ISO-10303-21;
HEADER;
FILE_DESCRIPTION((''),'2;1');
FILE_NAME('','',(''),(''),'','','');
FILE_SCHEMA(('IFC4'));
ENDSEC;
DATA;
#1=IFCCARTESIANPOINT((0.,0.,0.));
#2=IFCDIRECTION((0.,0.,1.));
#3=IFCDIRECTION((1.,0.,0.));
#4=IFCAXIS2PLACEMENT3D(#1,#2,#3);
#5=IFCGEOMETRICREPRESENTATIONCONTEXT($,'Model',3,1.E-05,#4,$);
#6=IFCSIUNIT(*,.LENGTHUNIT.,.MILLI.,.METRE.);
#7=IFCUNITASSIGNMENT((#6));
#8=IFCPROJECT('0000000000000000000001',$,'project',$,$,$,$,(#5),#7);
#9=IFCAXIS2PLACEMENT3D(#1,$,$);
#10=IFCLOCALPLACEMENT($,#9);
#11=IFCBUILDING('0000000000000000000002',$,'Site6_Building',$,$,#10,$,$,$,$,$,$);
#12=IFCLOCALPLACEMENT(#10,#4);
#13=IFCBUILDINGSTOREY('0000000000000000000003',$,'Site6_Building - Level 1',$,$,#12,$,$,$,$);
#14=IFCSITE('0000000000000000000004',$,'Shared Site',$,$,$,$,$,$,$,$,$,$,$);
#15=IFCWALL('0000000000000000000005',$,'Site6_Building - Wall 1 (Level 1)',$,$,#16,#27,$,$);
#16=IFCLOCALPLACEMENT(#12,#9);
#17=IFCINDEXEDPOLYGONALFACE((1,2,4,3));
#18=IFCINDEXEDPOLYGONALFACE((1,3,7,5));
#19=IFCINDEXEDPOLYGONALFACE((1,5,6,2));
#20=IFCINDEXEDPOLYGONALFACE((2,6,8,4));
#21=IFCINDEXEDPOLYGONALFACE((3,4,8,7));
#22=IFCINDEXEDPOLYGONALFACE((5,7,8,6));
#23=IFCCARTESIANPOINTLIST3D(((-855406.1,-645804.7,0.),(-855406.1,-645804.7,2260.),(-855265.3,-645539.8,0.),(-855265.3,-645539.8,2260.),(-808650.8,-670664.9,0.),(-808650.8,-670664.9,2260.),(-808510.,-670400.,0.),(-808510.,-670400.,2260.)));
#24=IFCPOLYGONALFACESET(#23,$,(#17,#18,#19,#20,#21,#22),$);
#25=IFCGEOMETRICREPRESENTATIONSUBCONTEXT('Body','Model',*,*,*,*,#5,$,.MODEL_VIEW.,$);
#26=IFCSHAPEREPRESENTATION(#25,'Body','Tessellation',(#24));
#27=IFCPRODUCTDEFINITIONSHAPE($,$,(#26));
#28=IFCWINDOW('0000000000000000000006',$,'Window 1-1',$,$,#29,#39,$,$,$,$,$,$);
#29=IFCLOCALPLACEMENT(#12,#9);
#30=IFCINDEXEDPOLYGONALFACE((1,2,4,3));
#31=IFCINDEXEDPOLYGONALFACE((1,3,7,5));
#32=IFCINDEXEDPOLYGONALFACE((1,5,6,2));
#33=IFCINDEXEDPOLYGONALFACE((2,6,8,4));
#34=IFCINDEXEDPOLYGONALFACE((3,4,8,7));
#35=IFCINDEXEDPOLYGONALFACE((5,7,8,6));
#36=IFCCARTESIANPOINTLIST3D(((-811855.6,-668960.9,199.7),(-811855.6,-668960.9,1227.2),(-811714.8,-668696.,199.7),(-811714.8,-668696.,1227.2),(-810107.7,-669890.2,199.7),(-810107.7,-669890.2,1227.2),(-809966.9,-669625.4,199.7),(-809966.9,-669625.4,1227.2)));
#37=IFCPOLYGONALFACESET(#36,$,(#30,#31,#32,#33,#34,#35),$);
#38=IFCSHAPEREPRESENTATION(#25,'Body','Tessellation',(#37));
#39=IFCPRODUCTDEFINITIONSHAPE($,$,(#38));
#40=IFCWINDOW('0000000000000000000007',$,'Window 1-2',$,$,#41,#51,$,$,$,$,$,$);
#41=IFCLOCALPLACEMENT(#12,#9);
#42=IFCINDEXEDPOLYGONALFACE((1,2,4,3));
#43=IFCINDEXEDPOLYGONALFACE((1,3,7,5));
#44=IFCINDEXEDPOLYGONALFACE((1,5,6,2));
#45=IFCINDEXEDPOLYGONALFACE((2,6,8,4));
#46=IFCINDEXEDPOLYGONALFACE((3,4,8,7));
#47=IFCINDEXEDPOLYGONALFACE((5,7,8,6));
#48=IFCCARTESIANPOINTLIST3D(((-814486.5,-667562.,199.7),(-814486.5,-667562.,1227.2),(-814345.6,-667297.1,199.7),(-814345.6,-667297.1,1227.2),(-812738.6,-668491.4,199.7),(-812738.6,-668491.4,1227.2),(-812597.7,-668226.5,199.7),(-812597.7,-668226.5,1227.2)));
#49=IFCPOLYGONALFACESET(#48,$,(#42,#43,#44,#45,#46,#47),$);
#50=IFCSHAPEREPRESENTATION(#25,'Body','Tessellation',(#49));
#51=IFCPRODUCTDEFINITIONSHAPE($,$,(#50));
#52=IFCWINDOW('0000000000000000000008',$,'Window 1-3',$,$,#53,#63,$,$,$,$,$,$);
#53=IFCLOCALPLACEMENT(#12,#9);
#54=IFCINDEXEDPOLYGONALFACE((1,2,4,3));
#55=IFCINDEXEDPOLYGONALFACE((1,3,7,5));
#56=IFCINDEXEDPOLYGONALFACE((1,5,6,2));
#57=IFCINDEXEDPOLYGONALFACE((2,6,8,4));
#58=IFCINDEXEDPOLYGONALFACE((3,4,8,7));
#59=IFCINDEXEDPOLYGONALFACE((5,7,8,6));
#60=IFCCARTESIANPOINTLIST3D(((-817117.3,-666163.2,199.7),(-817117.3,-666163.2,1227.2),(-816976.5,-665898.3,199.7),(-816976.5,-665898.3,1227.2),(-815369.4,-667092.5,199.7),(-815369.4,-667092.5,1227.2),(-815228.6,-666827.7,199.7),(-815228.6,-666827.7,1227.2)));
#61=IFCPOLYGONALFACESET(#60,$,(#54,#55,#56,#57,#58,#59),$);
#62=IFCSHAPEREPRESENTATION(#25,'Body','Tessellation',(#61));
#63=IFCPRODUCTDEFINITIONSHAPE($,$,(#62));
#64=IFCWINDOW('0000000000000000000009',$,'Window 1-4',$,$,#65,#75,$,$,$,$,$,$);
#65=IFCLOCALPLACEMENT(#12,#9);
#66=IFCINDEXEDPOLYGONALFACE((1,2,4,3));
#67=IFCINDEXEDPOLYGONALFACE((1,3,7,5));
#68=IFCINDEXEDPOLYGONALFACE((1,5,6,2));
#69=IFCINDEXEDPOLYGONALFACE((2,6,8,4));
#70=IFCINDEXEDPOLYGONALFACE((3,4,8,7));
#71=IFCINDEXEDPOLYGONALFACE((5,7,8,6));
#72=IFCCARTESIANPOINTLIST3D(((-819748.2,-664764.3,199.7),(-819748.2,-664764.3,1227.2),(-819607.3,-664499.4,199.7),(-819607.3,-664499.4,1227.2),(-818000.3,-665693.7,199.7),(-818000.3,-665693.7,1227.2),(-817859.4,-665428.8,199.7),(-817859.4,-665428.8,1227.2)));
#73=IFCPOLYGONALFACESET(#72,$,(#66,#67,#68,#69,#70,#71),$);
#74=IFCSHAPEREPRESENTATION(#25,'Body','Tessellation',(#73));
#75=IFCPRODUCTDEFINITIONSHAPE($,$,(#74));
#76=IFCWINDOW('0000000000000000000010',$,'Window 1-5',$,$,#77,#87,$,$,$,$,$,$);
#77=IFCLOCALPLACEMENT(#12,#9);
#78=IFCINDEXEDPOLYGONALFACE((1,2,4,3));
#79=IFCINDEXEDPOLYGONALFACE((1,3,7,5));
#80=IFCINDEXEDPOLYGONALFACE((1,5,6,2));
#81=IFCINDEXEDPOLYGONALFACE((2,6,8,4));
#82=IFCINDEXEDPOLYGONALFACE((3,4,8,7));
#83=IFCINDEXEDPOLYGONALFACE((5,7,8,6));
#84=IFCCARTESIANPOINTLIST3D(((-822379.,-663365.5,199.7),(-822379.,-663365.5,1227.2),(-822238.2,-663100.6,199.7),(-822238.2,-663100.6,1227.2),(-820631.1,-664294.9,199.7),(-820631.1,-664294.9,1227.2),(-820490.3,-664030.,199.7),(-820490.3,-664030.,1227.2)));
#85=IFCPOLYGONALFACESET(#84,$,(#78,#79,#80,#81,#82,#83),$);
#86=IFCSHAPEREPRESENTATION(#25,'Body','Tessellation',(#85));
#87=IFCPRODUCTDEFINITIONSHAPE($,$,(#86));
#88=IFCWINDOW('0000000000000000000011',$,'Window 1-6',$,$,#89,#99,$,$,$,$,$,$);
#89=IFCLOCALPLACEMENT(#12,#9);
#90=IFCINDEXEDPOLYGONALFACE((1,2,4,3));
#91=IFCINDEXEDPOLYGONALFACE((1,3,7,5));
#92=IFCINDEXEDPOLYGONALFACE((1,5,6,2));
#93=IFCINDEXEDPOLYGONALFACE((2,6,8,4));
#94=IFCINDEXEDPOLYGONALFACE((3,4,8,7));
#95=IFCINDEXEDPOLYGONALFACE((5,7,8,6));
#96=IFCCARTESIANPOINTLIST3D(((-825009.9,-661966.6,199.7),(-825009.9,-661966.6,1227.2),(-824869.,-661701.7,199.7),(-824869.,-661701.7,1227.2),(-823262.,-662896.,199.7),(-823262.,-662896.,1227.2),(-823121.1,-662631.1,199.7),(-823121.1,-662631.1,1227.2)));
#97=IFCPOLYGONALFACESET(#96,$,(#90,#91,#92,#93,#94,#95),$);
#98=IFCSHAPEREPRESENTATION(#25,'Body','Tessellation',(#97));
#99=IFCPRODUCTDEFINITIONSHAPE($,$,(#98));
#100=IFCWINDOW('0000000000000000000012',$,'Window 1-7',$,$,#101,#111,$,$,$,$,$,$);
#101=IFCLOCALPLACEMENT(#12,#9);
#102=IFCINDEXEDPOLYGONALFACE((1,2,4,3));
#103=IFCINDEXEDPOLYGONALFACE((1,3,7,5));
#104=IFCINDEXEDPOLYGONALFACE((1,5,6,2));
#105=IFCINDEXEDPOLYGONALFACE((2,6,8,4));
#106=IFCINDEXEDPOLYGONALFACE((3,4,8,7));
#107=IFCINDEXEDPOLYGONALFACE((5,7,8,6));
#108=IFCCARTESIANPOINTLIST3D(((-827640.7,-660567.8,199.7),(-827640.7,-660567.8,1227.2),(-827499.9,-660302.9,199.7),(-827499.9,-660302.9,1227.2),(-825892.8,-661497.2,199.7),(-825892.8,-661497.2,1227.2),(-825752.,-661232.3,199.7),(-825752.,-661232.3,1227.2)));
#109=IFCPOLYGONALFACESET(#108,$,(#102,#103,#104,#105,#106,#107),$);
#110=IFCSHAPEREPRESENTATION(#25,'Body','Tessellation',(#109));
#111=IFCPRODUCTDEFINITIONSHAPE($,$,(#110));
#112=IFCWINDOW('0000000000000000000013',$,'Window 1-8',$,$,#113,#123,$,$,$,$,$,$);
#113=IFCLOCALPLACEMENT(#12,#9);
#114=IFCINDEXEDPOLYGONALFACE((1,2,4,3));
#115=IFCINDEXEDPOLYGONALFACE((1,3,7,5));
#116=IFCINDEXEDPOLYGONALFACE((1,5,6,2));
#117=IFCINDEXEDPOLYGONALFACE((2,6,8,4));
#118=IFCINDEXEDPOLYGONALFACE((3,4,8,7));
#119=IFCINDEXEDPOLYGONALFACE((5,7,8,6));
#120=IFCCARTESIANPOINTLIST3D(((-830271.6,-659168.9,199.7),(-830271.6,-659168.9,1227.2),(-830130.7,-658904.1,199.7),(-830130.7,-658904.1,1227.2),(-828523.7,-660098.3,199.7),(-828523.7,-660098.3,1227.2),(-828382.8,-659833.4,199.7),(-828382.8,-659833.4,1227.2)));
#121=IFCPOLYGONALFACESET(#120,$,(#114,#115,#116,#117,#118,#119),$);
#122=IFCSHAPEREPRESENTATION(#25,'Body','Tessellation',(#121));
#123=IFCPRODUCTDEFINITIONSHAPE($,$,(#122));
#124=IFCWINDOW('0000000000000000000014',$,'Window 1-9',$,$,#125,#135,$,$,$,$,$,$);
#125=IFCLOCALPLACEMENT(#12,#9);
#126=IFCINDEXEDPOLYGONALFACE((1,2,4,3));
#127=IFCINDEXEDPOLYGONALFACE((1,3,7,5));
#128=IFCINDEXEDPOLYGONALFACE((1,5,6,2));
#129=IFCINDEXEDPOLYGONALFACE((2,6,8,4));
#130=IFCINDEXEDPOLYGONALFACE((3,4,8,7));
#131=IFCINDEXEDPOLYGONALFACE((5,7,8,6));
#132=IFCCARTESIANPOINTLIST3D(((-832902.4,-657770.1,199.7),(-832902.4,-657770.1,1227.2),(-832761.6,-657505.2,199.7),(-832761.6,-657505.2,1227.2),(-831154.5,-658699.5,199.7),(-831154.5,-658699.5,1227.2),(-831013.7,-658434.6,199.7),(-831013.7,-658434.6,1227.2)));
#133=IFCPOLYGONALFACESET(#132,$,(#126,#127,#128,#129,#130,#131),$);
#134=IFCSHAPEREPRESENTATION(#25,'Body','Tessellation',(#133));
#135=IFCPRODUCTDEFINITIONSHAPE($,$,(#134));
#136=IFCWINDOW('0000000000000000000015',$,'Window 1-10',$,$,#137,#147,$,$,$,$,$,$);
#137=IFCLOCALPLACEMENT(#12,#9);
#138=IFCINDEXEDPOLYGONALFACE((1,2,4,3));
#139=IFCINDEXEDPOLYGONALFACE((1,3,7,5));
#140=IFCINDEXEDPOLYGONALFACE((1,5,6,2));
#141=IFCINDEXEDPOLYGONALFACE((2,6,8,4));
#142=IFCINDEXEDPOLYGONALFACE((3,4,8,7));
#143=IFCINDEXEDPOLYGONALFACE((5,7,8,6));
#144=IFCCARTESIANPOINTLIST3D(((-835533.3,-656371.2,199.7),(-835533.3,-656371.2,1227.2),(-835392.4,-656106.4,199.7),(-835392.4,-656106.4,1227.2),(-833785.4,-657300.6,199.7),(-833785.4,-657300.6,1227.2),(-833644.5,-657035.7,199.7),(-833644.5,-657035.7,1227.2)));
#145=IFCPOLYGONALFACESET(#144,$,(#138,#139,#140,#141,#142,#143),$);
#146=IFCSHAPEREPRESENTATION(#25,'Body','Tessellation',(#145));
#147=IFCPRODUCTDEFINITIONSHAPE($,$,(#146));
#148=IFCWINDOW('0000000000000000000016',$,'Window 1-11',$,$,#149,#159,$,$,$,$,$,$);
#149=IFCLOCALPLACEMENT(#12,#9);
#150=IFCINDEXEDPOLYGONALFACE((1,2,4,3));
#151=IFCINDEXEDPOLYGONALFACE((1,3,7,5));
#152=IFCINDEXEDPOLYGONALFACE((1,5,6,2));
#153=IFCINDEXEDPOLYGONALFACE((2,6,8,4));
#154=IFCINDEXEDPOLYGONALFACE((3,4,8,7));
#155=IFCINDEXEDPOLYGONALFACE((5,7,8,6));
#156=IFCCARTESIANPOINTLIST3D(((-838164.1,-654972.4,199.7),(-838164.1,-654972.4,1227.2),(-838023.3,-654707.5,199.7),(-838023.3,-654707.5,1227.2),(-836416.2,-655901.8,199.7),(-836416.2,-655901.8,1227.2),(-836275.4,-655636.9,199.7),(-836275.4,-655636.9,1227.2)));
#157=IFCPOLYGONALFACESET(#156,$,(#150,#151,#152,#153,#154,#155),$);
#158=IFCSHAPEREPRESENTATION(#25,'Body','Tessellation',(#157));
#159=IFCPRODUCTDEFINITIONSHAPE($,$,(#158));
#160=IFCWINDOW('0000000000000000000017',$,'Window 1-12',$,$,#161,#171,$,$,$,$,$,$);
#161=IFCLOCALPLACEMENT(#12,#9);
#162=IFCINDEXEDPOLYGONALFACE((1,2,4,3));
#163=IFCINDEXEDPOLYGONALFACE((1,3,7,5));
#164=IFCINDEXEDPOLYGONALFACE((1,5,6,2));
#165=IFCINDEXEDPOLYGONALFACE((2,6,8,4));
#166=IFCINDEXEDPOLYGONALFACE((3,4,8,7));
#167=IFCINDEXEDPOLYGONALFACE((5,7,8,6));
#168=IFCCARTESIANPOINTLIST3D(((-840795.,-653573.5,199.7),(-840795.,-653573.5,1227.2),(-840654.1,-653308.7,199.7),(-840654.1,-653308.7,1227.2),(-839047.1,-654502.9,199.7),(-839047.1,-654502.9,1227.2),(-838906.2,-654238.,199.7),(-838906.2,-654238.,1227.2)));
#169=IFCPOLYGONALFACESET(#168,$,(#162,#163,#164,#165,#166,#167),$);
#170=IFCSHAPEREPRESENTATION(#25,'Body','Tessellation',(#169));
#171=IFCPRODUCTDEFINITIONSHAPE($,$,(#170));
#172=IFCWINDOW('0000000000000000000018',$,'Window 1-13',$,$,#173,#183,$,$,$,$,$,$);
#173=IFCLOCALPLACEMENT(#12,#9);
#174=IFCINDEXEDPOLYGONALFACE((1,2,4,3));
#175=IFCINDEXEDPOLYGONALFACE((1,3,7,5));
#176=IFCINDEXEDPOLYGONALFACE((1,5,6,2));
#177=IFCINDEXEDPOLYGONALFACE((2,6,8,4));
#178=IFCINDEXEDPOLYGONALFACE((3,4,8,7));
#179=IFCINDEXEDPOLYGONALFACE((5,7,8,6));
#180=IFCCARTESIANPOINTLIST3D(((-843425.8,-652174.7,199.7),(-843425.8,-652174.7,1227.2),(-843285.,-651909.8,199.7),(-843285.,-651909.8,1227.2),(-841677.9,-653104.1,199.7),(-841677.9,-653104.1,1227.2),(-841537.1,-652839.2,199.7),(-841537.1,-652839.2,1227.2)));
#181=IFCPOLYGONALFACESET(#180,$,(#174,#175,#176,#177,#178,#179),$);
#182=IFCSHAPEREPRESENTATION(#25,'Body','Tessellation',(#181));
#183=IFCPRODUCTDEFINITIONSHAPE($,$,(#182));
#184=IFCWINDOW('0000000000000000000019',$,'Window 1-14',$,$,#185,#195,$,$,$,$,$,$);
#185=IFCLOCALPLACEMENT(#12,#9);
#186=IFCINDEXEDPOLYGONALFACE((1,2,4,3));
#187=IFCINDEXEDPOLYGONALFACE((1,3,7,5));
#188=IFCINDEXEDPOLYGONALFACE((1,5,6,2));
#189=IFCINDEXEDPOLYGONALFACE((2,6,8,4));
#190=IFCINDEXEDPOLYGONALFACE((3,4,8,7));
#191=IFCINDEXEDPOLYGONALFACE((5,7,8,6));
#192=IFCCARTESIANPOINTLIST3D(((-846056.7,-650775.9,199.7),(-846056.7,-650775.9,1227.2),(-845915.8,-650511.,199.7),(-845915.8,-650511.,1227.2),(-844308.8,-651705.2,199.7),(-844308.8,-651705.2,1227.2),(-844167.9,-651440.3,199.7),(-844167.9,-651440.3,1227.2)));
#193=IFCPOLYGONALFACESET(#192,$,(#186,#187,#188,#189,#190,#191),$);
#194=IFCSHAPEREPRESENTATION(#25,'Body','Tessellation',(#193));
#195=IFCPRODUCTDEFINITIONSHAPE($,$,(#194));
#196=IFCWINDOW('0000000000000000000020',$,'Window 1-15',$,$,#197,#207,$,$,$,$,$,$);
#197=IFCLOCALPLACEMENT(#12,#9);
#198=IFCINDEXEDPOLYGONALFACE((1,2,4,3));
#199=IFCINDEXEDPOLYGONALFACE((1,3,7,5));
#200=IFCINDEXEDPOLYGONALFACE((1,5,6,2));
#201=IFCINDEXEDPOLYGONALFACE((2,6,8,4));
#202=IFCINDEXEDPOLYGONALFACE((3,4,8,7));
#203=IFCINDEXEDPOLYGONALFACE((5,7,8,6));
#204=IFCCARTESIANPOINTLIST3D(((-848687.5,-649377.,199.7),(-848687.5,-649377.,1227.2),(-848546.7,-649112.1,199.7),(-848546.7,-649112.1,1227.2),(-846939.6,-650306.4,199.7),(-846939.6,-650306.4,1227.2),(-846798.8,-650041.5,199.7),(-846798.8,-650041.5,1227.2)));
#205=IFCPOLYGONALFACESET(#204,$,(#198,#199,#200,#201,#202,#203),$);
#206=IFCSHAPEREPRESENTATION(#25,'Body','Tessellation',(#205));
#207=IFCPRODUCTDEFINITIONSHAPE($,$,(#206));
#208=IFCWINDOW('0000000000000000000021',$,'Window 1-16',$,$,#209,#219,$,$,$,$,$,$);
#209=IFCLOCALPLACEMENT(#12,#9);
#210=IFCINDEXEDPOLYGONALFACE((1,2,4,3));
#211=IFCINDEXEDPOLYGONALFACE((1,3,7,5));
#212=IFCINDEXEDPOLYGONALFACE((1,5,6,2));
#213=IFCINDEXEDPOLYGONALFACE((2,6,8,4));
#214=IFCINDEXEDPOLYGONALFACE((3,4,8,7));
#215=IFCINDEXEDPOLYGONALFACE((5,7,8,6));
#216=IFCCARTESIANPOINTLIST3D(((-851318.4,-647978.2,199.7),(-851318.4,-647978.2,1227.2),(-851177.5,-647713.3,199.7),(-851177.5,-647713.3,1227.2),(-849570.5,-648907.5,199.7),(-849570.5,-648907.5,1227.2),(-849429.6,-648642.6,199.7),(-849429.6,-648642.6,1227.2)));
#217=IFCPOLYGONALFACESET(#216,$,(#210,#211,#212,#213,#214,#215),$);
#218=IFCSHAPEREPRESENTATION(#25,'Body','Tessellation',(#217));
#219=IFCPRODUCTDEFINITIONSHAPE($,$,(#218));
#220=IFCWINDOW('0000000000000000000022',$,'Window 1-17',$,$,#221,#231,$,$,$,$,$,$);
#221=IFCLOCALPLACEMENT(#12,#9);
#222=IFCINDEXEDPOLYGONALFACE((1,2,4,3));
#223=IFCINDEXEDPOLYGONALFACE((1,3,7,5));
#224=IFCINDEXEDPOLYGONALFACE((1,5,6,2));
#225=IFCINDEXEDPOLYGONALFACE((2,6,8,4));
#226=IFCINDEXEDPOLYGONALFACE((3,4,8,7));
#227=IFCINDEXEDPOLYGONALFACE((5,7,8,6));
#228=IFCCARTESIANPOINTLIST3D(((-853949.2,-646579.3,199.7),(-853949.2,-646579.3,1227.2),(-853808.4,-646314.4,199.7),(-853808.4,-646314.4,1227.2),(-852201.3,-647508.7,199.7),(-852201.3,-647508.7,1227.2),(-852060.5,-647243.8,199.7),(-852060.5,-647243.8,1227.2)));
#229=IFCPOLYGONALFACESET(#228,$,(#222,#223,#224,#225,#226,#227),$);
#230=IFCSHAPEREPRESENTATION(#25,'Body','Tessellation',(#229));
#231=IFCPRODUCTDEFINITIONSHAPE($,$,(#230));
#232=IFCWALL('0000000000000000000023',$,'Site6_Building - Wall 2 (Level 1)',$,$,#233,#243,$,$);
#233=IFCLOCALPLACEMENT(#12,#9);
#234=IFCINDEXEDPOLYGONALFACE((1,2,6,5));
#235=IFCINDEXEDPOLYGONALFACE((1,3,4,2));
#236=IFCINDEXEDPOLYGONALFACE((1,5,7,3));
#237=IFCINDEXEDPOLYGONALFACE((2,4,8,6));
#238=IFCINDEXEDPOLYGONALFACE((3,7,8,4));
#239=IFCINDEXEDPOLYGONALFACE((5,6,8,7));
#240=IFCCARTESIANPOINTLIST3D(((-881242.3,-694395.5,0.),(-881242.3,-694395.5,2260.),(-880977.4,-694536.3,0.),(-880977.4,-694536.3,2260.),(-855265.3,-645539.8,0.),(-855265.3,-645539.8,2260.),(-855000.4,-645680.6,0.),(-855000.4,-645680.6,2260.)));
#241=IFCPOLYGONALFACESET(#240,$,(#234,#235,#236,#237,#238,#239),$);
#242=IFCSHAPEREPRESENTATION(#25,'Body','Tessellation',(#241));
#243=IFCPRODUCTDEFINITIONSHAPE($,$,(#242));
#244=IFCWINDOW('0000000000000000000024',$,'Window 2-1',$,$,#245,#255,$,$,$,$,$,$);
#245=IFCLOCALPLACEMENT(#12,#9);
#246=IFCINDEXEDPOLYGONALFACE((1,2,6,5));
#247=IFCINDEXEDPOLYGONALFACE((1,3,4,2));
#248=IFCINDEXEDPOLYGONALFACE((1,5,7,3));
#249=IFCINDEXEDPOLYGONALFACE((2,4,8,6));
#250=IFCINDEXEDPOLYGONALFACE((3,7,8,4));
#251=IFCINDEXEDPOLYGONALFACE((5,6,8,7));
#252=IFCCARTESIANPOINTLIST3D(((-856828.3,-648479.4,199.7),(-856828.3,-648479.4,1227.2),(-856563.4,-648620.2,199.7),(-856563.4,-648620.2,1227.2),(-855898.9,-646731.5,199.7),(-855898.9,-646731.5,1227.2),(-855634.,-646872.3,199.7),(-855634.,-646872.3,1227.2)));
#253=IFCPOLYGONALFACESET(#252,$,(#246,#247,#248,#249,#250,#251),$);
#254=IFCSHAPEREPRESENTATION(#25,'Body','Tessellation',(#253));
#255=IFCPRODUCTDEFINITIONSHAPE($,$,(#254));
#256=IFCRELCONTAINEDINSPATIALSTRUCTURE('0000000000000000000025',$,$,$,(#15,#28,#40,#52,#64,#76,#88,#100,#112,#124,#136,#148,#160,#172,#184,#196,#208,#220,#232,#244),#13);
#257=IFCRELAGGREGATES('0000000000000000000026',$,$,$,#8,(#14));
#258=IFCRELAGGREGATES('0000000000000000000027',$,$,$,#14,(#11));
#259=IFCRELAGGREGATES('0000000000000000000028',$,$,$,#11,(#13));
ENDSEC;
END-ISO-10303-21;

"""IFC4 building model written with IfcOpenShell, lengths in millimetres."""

from ifc_helpers import new_model, si_unit, frame, origin, origin_with_axes, place, context, subcontext, project, spatial, indexed_curve, outline, extrude, element, save


model = new_model("IFC4")

# Units and contexts
model_context = context("Model", 3, precision=1e-05, world=origin_with_axes())
body_context = subcontext(model_context, "Body", "Model", "MODEL_VIEW")
ifc_project = project(units=[si_unit("LENGTHUNIT", "METRE", prefix="MILLI")], contexts=[model_context])

# Site, building, storey
site = spatial("IfcSite", under=ifc_project, Name="Shared Site")
building_placement = place(None, origin())
building = spatial("IfcBuilding", under=site, at=building_placement, Name="Site6_Building")
storey_placement = place(building_placement, origin_with_axes())
storey = spatial("IfcBuildingStorey", under=building, at=storey_placement, Name="Site6_Building - Level 1")

# Wall
wall_1_placement = place(storey_placement, frame((-808510.0, -670400.0, 0.0), z_axis=(0.0, 0.0, 1.0), x_axis=(-0.882948, 0.469472, 0.0)))
element("IfcWall", 1, at=wall_1_placement, inside=storey, Name="Site6_Building - Wall 1 (Level 1)", context=body_context, shape_type="SweptSolid", body=[
    extrude(outline(indexed_curve([(0.0, 0.0), (0.0, 300.0), (52953.6, 300.0), (52953.6, 0.0), (0.0, 0.0)], self_intersect=False)), origin_with_axes(), (0.0, 0.0, 1.0), 2260.0),
])

# Windows
for number, where, z_axis, x_axis, name in (
    (2, (-809966.9, -669625.4, 199.7), (0.0, 0.0, 1.0), (-0.882948, 0.469472, 0.0), "Window 1-1"),
    (3, (-812597.7, -668226.5, 199.7), (0.0, 0.0, 1.0), (-0.882948, 0.469472, 0.0), "Window 1-2"),
    (4, (-815228.6, -666827.7, 199.7), (0.0, 0.0, 1.0), (-0.882948, 0.469472, 0.0), "Window 1-3"),
    (5, (-817859.4, -665428.8, 199.7), (0.0, 0.0, 1.0), (-0.882948, 0.469472, 0.0), "Window 1-4"),
    (6, (-820490.3, -664030.0, 199.7), (0.0, 0.0, 1.0), (-0.882948, 0.469472, 0.0), "Window 1-5"),
    (7, (-823121.1, -662631.1, 199.7), (0.0, 0.0, 1.0), (-0.882948, 0.469472, 0.0), "Window 1-6"),
    (8, (-825752.0, -661232.3, 199.7), (0.0, 0.0, 1.0), (-0.882948, 0.469472, 0.0), "Window 1-7"),
    (9, (-828382.8, -659833.4, 199.7), (0.0, 0.0, 1.0), (-0.882948, 0.469472, 0.0), "Window 1-8"),
    (10, (-831013.7, -658434.6, 199.7), (0.0, 0.0, 1.0), (-0.882948, 0.469472, 0.0), "Window 1-9"),
    (11, (-833644.5, -657035.7, 199.7), (0.0, 0.0, 1.0), (-0.882948, 0.469472, 0.0), "Window 1-10"),
    (12, (-836275.4, -655636.9, 199.7), (0.0, 0.0, 1.0), (-0.882948, 0.469472, 0.0), "Window 1-11"),
    (13, (-838906.2, -654238.0, 199.7), (0.0, 0.0, 1.0), (-0.882948, 0.469472, 0.0), "Window 1-12"),
    (14, (-841537.1, -652839.2, 199.7), (0.0, 0.0, 1.0), (-0.882948, 0.469472, 0.0), "Window 1-13"),
    (15, (-844167.9, -651440.3, 199.7), (0.0, 0.0, 1.0), (-0.882948, 0.469472, 0.0), "Window 1-14"),
    (16, (-846798.8, -650041.5, 199.7), (0.0, 0.0, 1.0), (-0.882948, 0.469472, 0.0), "Window 1-15"),
    (17, (-849429.6, -648642.6, 199.7), (0.0, 0.0, 1.0), (-0.882948, 0.469472, 0.0), "Window 1-16"),
    (18, (-852060.5, -647243.8, 199.7), (0.0, 0.0, 1.0), (-0.882948, 0.469472, 0.0), "Window 1-17"),
):
    element("IfcWindow", number, at=place(storey_placement, frame(where, z_axis=z_axis, x_axis=x_axis)), inside=storey, Name=name, context=body_context, shape_type="SweptSolid", body=[
        extrude(outline(indexed_curve([(0.0, 0.0), (0.0, 300.0), (1979.6, 300.0), (1979.6, 0.0), (0.0, 0.0)], self_intersect=False)), origin_with_axes(), (0.0, 0.0, 1.0), 1027.5),
    ])

# Wall
wall_2_placement = place(storey_placement, frame((-855265.3, -645539.8, 0.0), z_axis=(0.0, 0.0, 1.0), x_axis=(-0.469472, -0.882948, 0.0)))
element("IfcWall", 19, at=wall_2_placement, inside=storey, Name="Site6_Building - Wall 2 (Level 1)", context=body_context, shape_type="SweptSolid", body=[
    extrude(outline(indexed_curve([(0.0, 0.0), (0.0, 300.0), (55332.5, 300.0), (55332.5, 0.0), (0.0, 0.0)], self_intersect=False)), origin_with_axes(), (0.0, 0.0, 1.0), 2260.0),
])

# Window
for number, where, z_axis, x_axis, name in (
    (20, (-855898.9, -646731.5, 199.7), (0.0, 0.0, 1.0), (-0.469472, -0.882948, 0.0), "Window 2-1"),
):
    element("IfcWindow", number, at=place(storey_placement, frame(where, z_axis=z_axis, x_axis=x_axis)), inside=storey, Name=name, context=body_context, shape_type="SweptSolid", body=[
        extrude(outline(indexed_curve([(0.0, 0.0), (0.0, 300.0), (1979.6, 300.0), (1979.6, 0.0), (0.0, 0.0)], self_intersect=False)), origin_with_axes(), (0.0, 0.0, 1.0), 1027.5),
    ])

save(model, "model.ifc")
